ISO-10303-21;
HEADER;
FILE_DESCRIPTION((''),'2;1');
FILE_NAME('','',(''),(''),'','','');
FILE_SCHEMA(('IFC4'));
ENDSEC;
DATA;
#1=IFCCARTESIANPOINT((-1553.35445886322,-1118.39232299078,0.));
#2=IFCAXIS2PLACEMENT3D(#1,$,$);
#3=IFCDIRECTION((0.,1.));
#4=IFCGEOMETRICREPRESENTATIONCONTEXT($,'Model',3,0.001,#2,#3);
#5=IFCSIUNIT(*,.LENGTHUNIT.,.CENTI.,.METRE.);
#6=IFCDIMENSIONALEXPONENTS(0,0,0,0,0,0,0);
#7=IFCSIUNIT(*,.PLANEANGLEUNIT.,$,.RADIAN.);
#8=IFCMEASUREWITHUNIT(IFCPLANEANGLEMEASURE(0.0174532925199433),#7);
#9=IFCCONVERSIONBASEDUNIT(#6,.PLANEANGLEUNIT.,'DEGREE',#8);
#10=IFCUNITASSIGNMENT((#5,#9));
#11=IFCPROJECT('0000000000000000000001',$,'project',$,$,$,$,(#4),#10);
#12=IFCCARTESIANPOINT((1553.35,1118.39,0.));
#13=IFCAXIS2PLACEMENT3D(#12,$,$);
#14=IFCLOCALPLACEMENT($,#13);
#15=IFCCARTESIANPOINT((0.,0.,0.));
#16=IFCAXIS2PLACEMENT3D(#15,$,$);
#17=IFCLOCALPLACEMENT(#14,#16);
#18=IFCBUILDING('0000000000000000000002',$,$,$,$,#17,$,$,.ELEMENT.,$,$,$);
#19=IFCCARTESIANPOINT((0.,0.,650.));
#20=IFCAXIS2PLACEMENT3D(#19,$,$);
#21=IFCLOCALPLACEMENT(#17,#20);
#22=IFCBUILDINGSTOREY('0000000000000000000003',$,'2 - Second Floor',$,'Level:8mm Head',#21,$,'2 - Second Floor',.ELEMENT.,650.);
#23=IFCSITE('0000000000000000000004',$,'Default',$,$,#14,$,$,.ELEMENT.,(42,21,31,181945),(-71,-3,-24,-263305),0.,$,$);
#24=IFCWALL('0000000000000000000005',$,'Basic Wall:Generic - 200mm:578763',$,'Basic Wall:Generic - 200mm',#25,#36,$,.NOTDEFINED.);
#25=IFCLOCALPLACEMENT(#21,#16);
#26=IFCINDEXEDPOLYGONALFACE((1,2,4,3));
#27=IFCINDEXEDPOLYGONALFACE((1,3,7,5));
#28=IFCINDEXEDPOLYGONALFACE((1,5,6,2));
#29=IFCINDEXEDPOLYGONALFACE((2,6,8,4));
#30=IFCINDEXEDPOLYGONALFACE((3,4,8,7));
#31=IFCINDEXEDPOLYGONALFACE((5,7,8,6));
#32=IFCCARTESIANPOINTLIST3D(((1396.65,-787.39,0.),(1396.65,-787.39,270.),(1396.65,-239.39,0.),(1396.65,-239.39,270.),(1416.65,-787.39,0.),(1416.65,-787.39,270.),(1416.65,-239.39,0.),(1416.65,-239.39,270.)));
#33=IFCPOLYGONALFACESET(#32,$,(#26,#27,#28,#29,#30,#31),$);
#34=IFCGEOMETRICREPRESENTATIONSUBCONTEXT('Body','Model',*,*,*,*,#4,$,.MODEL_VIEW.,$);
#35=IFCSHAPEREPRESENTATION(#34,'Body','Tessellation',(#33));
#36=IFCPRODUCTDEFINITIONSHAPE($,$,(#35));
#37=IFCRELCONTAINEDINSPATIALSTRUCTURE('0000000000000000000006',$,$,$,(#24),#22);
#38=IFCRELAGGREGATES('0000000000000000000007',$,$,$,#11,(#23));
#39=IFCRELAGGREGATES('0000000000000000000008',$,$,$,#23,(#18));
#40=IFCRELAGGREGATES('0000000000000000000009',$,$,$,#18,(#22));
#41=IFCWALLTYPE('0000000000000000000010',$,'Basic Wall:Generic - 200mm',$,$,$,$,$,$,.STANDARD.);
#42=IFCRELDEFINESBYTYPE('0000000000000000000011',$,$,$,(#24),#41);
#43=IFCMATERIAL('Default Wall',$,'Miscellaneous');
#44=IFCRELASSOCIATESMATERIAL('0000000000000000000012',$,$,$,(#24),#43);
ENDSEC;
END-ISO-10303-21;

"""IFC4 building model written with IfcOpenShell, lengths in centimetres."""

from ifc_helpers import new_model, entity, si_unit, converted_unit, direction, frame, origin, place, context, subcontext, project, spatial, indexed_curve, outline, extrude, material, type_object, element, save


model = new_model("IFC4")

# Units and contexts
model_context = context("Model", 3, precision=0.001, world=frame((-1553.35445886322, -1118.39232299078, 0.0)), true_north=direction((0.0, 1.0)))
body_context = subcontext(model_context, "Body", "Model", "MODEL_VIEW")
ifc_project = project(units=[si_unit("LENGTHUNIT", "METRE", prefix="CENTI"), converted_unit("PLANEANGLEUNIT", "DEGREE", entity("IfcPlaneAngleMeasure", 0.0174532925199433), si_unit("PLANEANGLEUNIT", "RADIAN"), dimensions=[0, 0, 0, 0, 0, 0, 0])], contexts=[model_context])

# Site, building, storey
site_placement = place(None, frame((1553.35, 1118.39, 0.0)))
site = spatial("IfcSite", under=ifc_project, at=site_placement, Name="Default", CompositionType="ELEMENT", RefLatitude=(42, 21, 31, 181945), RefLongitude=(-71, -3, -24, -263305), RefElevation=0.0)
building_placement = place(site_placement, origin())
building = spatial("IfcBuilding", under=site, at=building_placement, CompositionType="ELEMENT")
storey_placement = place(building_placement, frame((0.0, 0.0, 650.0)))
storey = spatial("IfcBuildingStorey", under=building, at=storey_placement, Name="2 - Second Floor", ObjectType="Level:8mm Head", LongName="2 - Second Floor", CompositionType="ELEMENT", Elevation=650.0)

# Wall
ifc_material_1 = material(Name="Default Wall", Category="Miscellaneous")
wall_type_1 = type_object("IfcWallType", Name="Basic Wall:Generic - 200mm", PredefinedType="STANDARD")
wall_1_placement = place(storey_placement, frame((1406.65, -239.39, 0.0), z_axis=(0.0, 0.0, 1.0), x_axis=(0.0, -1.0, 0.0)))
element("IfcWall", 1, at=wall_1_placement, inside=storey, type_object=wall_type_1, material=ifc_material_1, Name="Basic Wall:Generic - 200mm:578763", ObjectType="Basic Wall:Generic - 200mm", PredefinedType="NOTDEFINED", context=body_context, shape_type="SweptSolid", body=[
    extrude(outline(indexed_curve([(548.0, 10.0), (0.0, 10.0), (0.0, -10.0), (548.0, -10.0), (548.0, 10.0)], self_intersect=False)), origin(), (0.0, 0.0, 1.0), 270.0),
])

save(model, "model.ifc")
